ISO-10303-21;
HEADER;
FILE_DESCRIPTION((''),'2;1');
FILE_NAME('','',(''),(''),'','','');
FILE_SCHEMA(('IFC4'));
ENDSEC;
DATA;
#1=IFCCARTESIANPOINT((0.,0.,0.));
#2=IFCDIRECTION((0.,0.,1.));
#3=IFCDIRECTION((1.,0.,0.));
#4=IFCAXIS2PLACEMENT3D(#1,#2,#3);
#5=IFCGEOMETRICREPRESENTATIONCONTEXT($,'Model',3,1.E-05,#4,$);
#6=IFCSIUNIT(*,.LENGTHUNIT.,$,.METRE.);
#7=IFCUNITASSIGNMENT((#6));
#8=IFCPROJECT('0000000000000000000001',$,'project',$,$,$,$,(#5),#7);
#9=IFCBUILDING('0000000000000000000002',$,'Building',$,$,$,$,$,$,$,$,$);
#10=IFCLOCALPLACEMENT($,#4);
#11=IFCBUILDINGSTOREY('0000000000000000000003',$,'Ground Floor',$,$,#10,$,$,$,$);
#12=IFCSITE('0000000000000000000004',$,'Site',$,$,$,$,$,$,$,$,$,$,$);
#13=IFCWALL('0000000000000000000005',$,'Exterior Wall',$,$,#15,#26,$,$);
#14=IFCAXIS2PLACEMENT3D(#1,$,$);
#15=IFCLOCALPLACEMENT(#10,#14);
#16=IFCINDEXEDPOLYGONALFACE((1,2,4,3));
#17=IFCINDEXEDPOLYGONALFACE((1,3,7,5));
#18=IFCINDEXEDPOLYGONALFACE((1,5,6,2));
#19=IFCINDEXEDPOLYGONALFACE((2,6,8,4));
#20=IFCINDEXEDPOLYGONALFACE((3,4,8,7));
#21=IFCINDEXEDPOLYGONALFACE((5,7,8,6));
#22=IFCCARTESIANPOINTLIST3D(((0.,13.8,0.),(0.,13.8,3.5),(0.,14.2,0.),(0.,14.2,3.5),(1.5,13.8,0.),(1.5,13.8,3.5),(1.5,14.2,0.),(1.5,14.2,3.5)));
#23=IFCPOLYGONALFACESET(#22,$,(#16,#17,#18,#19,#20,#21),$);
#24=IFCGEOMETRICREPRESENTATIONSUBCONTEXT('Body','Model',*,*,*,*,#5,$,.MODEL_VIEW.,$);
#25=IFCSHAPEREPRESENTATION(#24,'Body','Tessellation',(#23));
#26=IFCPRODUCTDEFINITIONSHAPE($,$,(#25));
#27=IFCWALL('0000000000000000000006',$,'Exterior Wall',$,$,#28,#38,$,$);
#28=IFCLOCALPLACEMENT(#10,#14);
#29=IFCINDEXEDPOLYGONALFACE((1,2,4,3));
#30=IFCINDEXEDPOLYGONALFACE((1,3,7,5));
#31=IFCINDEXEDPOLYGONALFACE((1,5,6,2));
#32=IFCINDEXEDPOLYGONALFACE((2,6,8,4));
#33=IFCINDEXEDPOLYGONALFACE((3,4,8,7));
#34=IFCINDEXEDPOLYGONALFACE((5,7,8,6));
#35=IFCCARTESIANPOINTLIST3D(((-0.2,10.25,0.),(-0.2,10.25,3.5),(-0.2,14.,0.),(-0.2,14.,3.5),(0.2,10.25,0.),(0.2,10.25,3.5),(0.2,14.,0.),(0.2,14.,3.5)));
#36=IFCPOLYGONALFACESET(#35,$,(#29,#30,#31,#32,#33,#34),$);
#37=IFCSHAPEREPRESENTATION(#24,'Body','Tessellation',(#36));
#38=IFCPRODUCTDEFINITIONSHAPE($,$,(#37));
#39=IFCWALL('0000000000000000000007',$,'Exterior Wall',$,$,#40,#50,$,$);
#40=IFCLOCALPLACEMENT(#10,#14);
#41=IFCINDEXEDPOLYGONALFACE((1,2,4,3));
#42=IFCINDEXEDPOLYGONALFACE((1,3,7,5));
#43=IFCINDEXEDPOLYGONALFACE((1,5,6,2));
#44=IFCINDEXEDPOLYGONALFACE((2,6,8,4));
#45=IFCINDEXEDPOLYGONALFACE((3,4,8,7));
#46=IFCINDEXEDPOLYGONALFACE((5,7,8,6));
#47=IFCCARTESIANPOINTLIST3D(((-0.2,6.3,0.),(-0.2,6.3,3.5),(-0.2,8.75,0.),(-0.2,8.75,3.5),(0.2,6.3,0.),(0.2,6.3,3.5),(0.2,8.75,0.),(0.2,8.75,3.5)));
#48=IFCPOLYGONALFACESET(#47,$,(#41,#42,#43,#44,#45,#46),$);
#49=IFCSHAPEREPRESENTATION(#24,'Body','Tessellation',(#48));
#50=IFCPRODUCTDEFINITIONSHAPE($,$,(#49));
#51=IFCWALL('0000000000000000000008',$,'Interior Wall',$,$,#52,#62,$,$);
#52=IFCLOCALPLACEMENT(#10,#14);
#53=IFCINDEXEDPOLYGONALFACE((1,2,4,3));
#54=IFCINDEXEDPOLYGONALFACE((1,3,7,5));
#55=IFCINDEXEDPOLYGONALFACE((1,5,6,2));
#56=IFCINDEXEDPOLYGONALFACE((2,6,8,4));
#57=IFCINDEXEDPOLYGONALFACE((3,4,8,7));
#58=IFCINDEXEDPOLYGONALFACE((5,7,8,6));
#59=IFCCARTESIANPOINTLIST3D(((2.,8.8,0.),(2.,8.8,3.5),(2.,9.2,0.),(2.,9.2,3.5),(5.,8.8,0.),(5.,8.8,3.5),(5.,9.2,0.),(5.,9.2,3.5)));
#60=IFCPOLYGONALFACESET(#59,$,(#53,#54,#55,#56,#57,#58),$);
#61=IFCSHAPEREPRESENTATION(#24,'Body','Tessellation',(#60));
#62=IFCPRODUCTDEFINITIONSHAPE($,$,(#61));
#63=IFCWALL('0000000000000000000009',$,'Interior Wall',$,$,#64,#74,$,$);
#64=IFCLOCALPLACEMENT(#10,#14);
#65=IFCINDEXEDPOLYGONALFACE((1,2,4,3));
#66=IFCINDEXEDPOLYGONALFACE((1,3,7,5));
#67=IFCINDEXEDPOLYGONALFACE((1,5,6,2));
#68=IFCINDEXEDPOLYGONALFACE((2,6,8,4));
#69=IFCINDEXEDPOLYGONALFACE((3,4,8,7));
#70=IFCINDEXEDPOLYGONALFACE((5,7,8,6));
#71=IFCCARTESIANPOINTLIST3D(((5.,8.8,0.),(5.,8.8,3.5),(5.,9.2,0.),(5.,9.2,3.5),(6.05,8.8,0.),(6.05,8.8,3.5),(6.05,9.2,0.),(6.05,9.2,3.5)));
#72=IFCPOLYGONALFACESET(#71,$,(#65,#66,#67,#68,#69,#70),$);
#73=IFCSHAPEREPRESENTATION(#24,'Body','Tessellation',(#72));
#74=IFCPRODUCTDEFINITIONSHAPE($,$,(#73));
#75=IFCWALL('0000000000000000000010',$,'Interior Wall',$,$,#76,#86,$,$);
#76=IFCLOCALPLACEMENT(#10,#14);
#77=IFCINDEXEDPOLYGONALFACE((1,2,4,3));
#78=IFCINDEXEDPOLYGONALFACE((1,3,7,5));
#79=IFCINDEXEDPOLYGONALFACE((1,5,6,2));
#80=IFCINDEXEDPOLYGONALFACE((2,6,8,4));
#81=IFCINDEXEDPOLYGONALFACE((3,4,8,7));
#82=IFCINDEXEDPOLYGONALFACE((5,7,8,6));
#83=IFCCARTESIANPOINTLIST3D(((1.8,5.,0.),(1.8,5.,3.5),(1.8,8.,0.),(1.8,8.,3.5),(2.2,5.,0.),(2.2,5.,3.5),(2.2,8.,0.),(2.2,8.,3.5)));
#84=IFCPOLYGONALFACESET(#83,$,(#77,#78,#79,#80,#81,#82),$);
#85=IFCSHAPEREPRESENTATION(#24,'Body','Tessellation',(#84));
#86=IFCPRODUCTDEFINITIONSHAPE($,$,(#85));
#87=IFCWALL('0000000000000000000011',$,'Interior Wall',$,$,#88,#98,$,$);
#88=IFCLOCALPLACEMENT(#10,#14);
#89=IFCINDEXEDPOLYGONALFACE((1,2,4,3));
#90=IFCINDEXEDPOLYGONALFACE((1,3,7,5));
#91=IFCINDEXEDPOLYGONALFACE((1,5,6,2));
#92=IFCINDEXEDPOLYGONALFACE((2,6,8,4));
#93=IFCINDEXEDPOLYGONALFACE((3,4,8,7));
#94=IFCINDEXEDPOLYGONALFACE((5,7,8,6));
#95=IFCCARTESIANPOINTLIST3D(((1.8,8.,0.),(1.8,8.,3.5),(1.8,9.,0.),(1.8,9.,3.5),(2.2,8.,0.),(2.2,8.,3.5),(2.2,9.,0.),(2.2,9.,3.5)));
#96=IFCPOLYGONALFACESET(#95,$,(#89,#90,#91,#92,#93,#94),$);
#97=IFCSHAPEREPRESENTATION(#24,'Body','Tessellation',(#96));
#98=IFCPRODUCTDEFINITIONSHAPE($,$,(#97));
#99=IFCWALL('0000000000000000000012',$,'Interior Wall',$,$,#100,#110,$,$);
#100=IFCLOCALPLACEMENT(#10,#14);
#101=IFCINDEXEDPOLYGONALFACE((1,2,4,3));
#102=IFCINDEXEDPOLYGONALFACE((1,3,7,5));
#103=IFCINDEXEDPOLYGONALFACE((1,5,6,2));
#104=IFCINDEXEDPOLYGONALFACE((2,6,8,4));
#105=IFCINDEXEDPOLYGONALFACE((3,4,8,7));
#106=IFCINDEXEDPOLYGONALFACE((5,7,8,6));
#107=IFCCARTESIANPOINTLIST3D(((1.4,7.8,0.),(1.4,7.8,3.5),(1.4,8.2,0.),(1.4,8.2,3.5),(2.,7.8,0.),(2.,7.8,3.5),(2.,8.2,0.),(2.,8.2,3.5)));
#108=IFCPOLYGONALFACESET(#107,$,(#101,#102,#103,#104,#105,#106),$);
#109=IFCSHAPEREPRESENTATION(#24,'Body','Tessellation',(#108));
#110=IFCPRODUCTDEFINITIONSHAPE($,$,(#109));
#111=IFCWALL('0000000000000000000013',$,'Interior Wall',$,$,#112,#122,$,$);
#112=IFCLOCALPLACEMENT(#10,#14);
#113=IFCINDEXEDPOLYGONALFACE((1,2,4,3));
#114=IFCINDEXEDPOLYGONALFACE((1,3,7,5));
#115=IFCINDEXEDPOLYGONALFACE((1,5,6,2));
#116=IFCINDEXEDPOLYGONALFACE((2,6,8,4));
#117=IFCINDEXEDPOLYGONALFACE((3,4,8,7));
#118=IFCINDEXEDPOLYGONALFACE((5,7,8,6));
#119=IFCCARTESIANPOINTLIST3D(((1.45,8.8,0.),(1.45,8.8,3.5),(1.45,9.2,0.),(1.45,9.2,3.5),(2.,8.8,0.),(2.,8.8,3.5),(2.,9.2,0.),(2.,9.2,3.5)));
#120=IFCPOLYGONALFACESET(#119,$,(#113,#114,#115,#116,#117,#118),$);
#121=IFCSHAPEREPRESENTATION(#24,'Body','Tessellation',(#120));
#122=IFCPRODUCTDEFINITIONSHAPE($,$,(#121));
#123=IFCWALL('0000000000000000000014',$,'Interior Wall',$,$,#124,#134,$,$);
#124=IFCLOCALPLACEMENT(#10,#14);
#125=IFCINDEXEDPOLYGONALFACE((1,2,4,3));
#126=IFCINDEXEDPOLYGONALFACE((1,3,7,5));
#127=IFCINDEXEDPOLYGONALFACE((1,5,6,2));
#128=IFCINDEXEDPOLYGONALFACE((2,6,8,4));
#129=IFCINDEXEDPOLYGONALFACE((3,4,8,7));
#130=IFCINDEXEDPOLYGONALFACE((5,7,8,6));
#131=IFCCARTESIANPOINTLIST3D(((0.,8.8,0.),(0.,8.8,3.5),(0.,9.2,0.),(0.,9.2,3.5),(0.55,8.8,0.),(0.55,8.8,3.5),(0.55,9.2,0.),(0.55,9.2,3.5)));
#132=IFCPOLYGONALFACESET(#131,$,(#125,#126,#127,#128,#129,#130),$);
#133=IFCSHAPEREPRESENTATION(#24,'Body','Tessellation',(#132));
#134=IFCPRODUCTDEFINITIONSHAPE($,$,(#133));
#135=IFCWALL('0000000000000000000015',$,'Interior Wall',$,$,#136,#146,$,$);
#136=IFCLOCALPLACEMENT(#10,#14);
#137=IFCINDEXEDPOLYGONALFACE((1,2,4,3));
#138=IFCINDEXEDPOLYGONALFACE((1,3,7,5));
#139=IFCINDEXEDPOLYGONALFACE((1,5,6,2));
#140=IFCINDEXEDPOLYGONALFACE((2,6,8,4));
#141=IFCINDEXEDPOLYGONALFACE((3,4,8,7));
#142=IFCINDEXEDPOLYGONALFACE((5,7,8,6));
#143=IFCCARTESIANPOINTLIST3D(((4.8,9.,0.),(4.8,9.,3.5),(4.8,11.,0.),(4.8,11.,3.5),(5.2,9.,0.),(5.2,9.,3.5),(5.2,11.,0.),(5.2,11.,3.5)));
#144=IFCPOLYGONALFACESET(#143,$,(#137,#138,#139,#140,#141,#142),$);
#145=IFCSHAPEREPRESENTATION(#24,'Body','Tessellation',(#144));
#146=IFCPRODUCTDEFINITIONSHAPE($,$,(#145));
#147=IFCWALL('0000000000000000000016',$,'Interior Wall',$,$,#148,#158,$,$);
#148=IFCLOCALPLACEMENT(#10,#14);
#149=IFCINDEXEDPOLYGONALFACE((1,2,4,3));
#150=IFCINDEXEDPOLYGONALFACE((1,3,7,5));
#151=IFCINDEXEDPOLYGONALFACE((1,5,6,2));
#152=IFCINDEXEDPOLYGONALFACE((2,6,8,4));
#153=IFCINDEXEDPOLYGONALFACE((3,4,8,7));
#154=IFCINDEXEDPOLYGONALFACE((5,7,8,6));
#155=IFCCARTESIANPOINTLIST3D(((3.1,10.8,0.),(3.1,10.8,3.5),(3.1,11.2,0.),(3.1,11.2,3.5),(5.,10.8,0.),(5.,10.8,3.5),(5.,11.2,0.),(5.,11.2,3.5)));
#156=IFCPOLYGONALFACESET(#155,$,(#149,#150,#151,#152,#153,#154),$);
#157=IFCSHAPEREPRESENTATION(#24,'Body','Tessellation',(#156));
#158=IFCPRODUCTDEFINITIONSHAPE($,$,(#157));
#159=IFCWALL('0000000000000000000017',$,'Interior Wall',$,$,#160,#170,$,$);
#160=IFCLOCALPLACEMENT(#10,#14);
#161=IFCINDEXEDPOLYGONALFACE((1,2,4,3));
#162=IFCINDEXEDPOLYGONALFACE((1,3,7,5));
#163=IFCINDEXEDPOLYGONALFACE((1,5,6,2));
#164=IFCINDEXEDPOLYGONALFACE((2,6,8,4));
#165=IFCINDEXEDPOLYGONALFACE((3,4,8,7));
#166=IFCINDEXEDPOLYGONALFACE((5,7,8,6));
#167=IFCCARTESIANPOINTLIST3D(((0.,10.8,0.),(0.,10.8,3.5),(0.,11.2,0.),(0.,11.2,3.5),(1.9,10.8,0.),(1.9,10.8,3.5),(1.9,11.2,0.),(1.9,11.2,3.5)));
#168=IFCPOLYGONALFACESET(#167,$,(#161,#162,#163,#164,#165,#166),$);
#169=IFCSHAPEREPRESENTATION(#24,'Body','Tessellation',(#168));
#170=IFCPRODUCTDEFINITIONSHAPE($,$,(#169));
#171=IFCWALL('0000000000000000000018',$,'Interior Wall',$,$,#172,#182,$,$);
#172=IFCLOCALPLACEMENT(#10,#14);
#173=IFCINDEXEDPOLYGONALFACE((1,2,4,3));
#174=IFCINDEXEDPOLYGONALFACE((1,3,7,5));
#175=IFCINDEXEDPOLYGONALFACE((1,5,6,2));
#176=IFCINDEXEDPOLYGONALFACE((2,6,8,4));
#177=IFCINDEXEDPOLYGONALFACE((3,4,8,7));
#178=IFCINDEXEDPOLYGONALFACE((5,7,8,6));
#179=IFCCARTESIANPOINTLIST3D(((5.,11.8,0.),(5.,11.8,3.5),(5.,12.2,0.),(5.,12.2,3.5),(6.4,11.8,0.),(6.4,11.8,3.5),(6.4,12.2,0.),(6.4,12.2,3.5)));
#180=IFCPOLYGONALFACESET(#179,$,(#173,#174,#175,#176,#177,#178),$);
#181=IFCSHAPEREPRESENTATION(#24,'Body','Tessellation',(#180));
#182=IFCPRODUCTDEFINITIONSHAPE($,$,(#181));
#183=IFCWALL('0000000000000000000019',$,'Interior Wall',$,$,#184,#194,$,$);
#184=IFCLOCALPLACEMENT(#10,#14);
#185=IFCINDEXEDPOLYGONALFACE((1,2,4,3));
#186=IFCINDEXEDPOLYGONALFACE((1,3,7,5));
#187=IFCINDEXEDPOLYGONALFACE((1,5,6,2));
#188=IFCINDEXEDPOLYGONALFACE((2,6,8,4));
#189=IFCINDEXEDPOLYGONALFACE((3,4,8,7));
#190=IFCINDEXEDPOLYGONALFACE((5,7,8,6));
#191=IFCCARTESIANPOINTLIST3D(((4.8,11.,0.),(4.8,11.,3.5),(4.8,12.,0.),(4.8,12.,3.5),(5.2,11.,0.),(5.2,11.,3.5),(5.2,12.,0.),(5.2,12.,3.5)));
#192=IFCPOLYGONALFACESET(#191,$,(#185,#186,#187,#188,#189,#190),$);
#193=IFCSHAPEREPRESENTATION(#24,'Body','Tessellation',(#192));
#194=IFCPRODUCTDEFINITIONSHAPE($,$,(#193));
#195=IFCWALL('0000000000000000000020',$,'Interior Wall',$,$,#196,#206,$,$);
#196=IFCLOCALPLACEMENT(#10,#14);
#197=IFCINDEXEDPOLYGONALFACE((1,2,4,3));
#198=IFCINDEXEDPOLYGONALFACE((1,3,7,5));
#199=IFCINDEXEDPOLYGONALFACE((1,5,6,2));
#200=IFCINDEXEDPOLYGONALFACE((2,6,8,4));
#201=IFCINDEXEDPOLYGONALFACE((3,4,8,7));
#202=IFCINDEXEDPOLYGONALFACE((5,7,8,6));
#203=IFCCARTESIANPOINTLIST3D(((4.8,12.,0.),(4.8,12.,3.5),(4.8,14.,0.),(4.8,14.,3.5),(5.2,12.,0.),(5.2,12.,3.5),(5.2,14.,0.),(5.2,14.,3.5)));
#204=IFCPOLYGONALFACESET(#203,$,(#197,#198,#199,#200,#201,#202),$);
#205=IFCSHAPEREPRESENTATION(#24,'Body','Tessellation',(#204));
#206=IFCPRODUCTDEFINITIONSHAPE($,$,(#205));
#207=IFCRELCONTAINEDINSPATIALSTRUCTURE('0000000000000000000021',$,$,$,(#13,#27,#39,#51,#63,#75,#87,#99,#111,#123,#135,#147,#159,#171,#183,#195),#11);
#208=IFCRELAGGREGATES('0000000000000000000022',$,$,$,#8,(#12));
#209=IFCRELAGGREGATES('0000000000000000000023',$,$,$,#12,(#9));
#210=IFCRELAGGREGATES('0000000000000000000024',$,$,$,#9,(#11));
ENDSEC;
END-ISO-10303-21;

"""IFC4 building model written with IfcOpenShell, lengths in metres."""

from ifc_helpers import new_model, si_unit, frame, origin_with_axes, place, context, subcontext, project, spatial, indexed_curve, outline, extrude, element, save


model = new_model("IFC4")

# Units and contexts
model_context = context("Model", 3, precision=1e-05, world=origin_with_axes())
body_context = subcontext(model_context, "Body", "Model", "MODEL_VIEW")
ifc_project = project(units=[si_unit("LENGTHUNIT", "METRE")], contexts=[model_context])

# Site, building, storey
site = spatial("IfcSite", under=ifc_project, Name="Site")
building = spatial("IfcBuilding", under=site, Name="Building")
storey_placement = place(None, origin_with_axes())
storey = spatial("IfcBuildingStorey", under=building, at=storey_placement, Name="Ground Floor")

# Walls
wall_1_placement = place(storey_placement, frame((1.5, 14.0, 0.0), z_axis=(0.0, 0.0, 1.0), x_axis=(-1.0, 0.0, 0.0)))
element("IfcWall", 1, at=wall_1_placement, inside=storey, Name="Exterior Wall", context=body_context, shape_type="SweptSolid", body=[
    extrude(outline(indexed_curve([(0.0, 0.0), (0.0, 0.4), (1.5, 0.4), (1.5, 0.0), (0.0, 0.0)], self_intersect=False)), frame((0.0, -0.2, 0.0), z_axis=(0.0, 0.0, 1.0), x_axis=(1.0, 0.0, 0.0)), (0.0, 0.0, 1.0), 3.5),
])
wall_2_placement = place(storey_placement, frame((0.0, 14.0, 0.0), z_axis=(0.0, 0.0, 1.0), x_axis=(0.0, -1.0, 0.0)))
element("IfcWall", 2, at=wall_2_placement, inside=storey, Name="Exterior Wall", context=body_context, shape_type="SweptSolid", body=[
    extrude(outline(indexed_curve([(0.0, 0.0), (0.0, 0.4), (3.75, 0.4), (3.75, 0.0), (0.0, 0.0)], self_intersect=False)), frame((0.0, -0.2, 0.0), z_axis=(0.0, 0.0, 1.0), x_axis=(1.0, 0.0, 0.0)), (0.0, 0.0, 1.0), 3.5),
])
wall_3_placement = place(storey_placement, frame((0.0, 8.75, 0.0), z_axis=(0.0, 0.0, 1.0), x_axis=(0.0, -1.0, 0.0)))
element("IfcWall", 3, at=wall_3_placement, inside=storey, Name="Exterior Wall", context=body_context, shape_type="SweptSolid", body=[
    extrude(outline(indexed_curve([(0.0, 0.0), (0.0, 0.4), (2.45, 0.4), (2.45, 0.0), (0.0, 0.0)], self_intersect=False)), frame((0.0, -0.2, 0.0), z_axis=(0.0, 0.0, 1.0), x_axis=(1.0, 0.0, 0.0)), (0.0, 0.0, 1.0), 3.5),
])
wall_4_placement = place(storey_placement, frame((5.0, 9.0, 0.0), z_axis=(0.0, 0.0, 1.0), x_axis=(-1.0, 0.0, 0.0)))
element("IfcWall", 4, at=wall_4_placement, inside=storey, Name="Interior Wall", context=body_context, shape_type="SweptSolid", body=[
    extrude(outline(indexed_curve([(0.0, 0.0), (0.0, 0.4), (3.0, 0.4), (3.0, 0.0), (0.0, 0.0)], self_intersect=False)), frame((0.0, -0.2, 0.0), z_axis=(0.0, 0.0, 1.0), x_axis=(1.0, 0.0, 0.0)), (0.0, 0.0, 1.0), 3.5),
])
wall_5_placement = place(storey_placement, frame((6.05, 9.0, 0.0), z_axis=(0.0, 0.0, 1.0), x_axis=(-1.0, 0.0, 0.0)))
element("IfcWall", 5, at=wall_5_placement, inside=storey, Name="Interior Wall", context=body_context, shape_type="SweptSolid", body=[
    extrude(outline(indexed_curve([(0.0, 0.0), (0.0, 0.4), (1.05, 0.4), (1.05, 0.0), (0.0, 0.0)], self_intersect=False)), frame((0.0, -0.2, 0.0), z_axis=(0.0, 0.0, 1.0), x_axis=(1.0, 0.0, 0.0)), (0.0, 0.0, 1.0), 3.5),
])
wall_6_placement = place(storey_placement, frame((2.0, 8.0, 0.0), z_axis=(0.0, 0.0, 1.0), x_axis=(0.0, -1.0, 0.0)))
element("IfcWall", 6, at=wall_6_placement, inside=storey, Name="Interior Wall", context=body_context, shape_type="SweptSolid", body=[
    extrude(outline(indexed_curve([(0.0, 0.0), (0.0, 0.4), (3.0, 0.4), (3.0, 0.0), (0.0, 0.0)], self_intersect=False)), frame((0.0, -0.2, 0.0), z_axis=(0.0, 0.0, 1.0), x_axis=(1.0, 0.0, 0.0)), (0.0, 0.0, 1.0), 3.5),
])
wall_7_placement = place(storey_placement, frame((2.0, 9.0, 0.0), z_axis=(0.0, 0.0, 1.0), x_axis=(0.0, -1.0, 0.0)))
element("IfcWall", 7, at=wall_7_placement, inside=storey, Name="Interior Wall", context=body_context, shape_type="SweptSolid", body=[
    extrude(outline(indexed_curve([(0.0, 0.0), (0.0, 0.4), (1.0, 0.4), (1.0, 0.0), (0.0, 0.0)], self_intersect=False)), frame((0.0, -0.2, 0.0), z_axis=(0.0, 0.0, 1.0), x_axis=(1.0, 0.0, 0.0)), (0.0, 0.0, 1.0), 3.5),
])
wall_8_placement = place(storey_placement, frame((2.0, 8.0, 0.0), z_axis=(0.0, 0.0, 1.0), x_axis=(-1.0, 0.0, 0.0)))
element("IfcWall", 8, at=wall_8_placement, inside=storey, Name="Interior Wall", context=body_context, shape_type="SweptSolid", body=[
    extrude(outline(indexed_curve([(0.0, 0.0), (0.0, 0.4), (0.6, 0.4), (0.6, 0.0), (0.0, 0.0)], self_intersect=False)), frame((0.0, -0.2, 0.0), z_axis=(0.0, 0.0, 1.0), x_axis=(1.0, 0.0, 0.0)), (0.0, 0.0, 1.0), 3.5),
])
for number, where, z_axis, x_axis, name in (
    (9, (2.0, 9.0, 0.0), (0.0, 0.0, 1.0), (-1.0, 0.0, 0.0), "Interior Wall"),
    (10, (0.55, 9.0, 0.0), (0.0, 0.0, 1.0), (-1.0, 0.0, 0.0), "Interior Wall"),
):
    element("IfcWall", number, at=place(storey_placement, frame(where, z_axis=z_axis, x_axis=x_axis)), inside=storey, Name=name, context=body_context, shape_type="SweptSolid", body=[
        extrude(outline(indexed_curve([(0.0, 0.0), (0.0, 0.4), (0.55, 0.4), (0.55, 0.0), (0.0, 0.0)], self_intersect=False)), frame((0.0, -0.2, 0.0), z_axis=(0.0, 0.0, 1.0), x_axis=(1.0, 0.0, 0.0)), (0.0, 0.0, 1.0), 3.5),
    ])
wall_9_placement = place(storey_placement, frame((5.0, 9.0, 0.0), z_axis=(0.0, 0.0, 1.0), x_axis=(0.0, 1.0, 0.0)))
element("IfcWall", 11, at=wall_9_placement, inside=storey, Name="Interior Wall", context=body_context, shape_type="SweptSolid", body=[
    extrude(outline(indexed_curve([(0.0, 0.0), (0.0, 0.4), (2.0, 0.4), (2.0, 0.0), (0.0, 0.0)], self_intersect=False)), frame((0.0, -0.2, 0.0), z_axis=(0.0, 0.0, 1.0), x_axis=(1.0, 0.0, 0.0)), (0.0, 0.0, 1.0), 3.5),
])
for number, where, z_axis, x_axis, name in (
    (12, (5.0, 11.0, 0.0), (0.0, 0.0, 1.0), (-1.0, 0.0, 0.0), "Interior Wall"),
    (13, (1.9, 11.0, 0.0), (0.0, 0.0, 1.0), (-1.0, 0.0, 0.0), "Interior Wall"),
):
    element("IfcWall", number, at=place(storey_placement, frame(where, z_axis=z_axis, x_axis=x_axis)), inside=storey, Name=name, context=body_context, shape_type="SweptSolid", body=[
        extrude(outline(indexed_curve([(0.0, 0.0), (0.0, 0.4), (1.9, 0.4), (1.9, 0.0), (0.0, 0.0)], self_intersect=False)), frame((0.0, -0.2, 0.0), z_axis=(0.0, 0.0, 1.0), x_axis=(1.0, 0.0, 0.0)), (0.0, 0.0, 1.0), 3.5),
    ])
wall_10_placement = place(storey_placement, frame((6.4, 12.0, 0.0), z_axis=(0.0, 0.0, 1.0), x_axis=(-1.0, 0.0, 0.0)))
element("IfcWall", 14, at=wall_10_placement, inside=storey, Name="Interior Wall", context=body_context, shape_type="SweptSolid", body=[
    extrude(outline(indexed_curve([(0.0, 0.0), (0.0, 0.4), (1.4, 0.4), (1.4, 0.0), (0.0, 0.0)], self_intersect=False)), frame((0.0, -0.2, 0.0), z_axis=(0.0, 0.0, 1.0), x_axis=(1.0, 0.0, 0.0)), (0.0, 0.0, 1.0), 3.5),
])
wall_11_placement = place(storey_placement, frame((5.0, 12.0, 0.0), z_axis=(0.0, 0.0, 1.0), x_axis=(0.0, -1.0, 0.0)))
element("IfcWall", 15, at=wall_11_placement, inside=storey, Name="Interior Wall", context=body_context, shape_type="SweptSolid", body=[
    extrude(outline(indexed_curve([(0.0, 0.0), (0.0, 0.4), (1.0, 0.4), (1.0, 0.0), (0.0, 0.0)], self_intersect=False)), frame((0.0, -0.2, 0.0), z_axis=(0.0, 0.0, 1.0), x_axis=(1.0, 0.0, 0.0)), (0.0, 0.0, 1.0), 3.5),
])
wall_12_placement = place(storey_placement, frame((5.0, 12.0, 0.0), z_axis=(0.0, 0.0, 1.0), x_axis=(0.0, 1.0, 0.0)))
element("IfcWall", 16, at=wall_12_placement, inside=storey, Name="Interior Wall", context=body_context, shape_type="SweptSolid", body=[
    extrude(outline(indexed_curve([(0.0, 0.0), (0.0, 0.4), (2.0, 0.4), (2.0, 0.0), (0.0, 0.0)], self_intersect=False)), frame((0.0, -0.2, 0.0), z_axis=(0.0, 0.0, 1.0), x_axis=(1.0, 0.0, 0.0)), (0.0, 0.0, 1.0), 3.5),
])

save(model, "model.ifc")
